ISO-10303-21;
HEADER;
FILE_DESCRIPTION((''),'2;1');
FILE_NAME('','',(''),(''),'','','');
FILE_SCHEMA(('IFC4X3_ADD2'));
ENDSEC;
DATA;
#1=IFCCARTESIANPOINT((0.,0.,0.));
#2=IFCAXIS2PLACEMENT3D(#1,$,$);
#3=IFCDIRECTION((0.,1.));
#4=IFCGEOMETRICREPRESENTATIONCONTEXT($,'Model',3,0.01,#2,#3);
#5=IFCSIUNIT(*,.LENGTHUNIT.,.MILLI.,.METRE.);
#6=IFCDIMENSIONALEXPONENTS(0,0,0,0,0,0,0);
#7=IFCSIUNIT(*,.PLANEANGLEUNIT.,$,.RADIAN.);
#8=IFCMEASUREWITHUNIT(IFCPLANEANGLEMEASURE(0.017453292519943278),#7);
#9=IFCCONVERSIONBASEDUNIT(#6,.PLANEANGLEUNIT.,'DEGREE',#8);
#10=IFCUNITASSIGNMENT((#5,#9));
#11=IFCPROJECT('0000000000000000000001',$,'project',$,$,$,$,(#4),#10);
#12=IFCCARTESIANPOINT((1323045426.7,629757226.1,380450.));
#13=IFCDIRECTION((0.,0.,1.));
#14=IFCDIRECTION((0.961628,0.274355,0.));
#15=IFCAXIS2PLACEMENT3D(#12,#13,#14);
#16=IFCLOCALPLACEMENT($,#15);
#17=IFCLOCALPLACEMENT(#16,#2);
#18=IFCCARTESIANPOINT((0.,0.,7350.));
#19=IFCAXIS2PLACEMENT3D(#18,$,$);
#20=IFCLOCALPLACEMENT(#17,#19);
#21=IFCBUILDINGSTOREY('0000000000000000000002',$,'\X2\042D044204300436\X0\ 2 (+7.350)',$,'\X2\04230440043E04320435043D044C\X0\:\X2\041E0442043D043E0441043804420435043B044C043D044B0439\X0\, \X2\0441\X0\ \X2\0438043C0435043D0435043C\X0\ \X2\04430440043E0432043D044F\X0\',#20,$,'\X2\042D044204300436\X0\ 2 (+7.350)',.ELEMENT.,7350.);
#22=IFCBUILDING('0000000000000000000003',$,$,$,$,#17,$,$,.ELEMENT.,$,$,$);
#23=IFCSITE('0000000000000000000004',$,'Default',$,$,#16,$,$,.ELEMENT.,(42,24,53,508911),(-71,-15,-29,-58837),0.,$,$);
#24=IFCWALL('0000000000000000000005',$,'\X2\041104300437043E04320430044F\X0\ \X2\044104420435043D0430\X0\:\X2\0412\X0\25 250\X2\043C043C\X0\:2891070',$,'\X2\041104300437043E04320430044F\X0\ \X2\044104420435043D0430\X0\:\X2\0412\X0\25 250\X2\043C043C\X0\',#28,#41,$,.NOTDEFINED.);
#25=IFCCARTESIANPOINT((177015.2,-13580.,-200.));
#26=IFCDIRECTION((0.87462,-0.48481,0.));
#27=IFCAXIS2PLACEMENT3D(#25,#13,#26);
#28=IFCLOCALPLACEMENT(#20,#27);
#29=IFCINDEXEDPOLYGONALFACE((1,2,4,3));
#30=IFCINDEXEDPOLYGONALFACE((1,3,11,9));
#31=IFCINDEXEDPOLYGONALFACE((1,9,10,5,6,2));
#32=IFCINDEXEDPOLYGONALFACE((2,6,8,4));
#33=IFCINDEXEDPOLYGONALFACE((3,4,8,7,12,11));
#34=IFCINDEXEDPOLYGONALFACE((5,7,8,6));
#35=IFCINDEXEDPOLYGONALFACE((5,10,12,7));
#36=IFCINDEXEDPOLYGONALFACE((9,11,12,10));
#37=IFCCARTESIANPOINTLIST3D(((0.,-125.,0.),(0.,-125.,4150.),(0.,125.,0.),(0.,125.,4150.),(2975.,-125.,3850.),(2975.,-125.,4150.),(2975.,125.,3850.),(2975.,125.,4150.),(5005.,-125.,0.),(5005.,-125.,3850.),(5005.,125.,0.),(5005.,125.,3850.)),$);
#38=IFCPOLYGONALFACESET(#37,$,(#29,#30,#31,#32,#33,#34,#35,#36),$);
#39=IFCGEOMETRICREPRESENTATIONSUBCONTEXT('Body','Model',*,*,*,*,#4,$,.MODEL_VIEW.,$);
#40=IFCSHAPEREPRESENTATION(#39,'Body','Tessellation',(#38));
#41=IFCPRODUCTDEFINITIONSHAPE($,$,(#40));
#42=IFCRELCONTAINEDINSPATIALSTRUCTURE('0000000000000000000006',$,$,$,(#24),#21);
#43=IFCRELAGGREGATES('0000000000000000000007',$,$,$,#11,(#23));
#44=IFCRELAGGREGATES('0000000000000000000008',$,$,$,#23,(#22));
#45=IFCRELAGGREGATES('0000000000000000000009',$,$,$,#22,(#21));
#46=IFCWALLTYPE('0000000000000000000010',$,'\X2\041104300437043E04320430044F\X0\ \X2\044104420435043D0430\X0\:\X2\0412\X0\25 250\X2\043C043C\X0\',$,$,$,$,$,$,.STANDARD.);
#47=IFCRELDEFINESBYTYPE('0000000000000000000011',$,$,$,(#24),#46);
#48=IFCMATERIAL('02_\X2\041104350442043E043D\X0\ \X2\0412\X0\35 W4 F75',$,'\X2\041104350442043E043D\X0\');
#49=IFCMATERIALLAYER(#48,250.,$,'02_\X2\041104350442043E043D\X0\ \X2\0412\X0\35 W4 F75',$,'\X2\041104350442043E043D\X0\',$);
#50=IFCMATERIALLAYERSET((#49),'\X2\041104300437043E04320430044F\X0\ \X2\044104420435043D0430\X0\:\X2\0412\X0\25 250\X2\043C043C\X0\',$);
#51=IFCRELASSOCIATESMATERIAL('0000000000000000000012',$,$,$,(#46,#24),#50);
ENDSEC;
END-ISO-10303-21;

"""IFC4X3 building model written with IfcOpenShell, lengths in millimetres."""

from ifc_helpers import new_model, entity, si_unit, converted_unit, direction, frame, frame_2d, origin, place, context, subcontext, project, spatial, polyline, rectangle, extrude, clip, bounded_halfspace, material, layer, layer_set, type_object, element, save


model = new_model("IFC4X3")

# Units and contexts
model_context = context("Model", 3, precision=0.01, world=origin(), true_north=direction((0.0, 1.0)))
body_context = subcontext(model_context, "Body", "Model", "MODEL_VIEW")
ifc_project = project(units=[si_unit("LENGTHUNIT", "METRE", prefix="MILLI"), converted_unit("PLANEANGLEUNIT", "DEGREE", entity("IfcPlaneAngleMeasure", 0.017453292519943278), si_unit("PLANEANGLEUNIT", "RADIAN"), dimensions=[0, 0, 0, 0, 0, 0, 0])], contexts=[model_context])

# Site, building, storey
site_placement = place(None, frame((1323045426.7, 629757226.1, 380450.0), z_axis=(0.0, 0.0, 1.0), x_axis=(0.961628, 0.274355, 0.0)))
site = spatial("IfcSite", under=ifc_project, at=site_placement, Name="Default", CompositionType="ELEMENT", RefLatitude=(42, 24, 53, 508911), RefLongitude=(-71, -15, -29, -58837), RefElevation=0.0)
building_placement = place(site_placement, origin())
building = spatial("IfcBuilding", under=site, at=building_placement, CompositionType="ELEMENT")
storey_placement = place(building_placement, frame((0.0, 0.0, 7350.0)))
storey = spatial("IfcBuildingStorey", under=building, at=storey_placement, Name="Этаж 2 (+7.350)", ObjectType="Уровень:Относительный, с именем уровня", LongName="Этаж 2 (+7.350)", CompositionType="ELEMENT", Elevation=7350.0)

# Shared definitions
ifc_material = material(Name="02_Бетон В35 W4 F75", Category="Бетон")
ifc_layer_1 = layer(ifc_material, 250.0, Name="02_Бетон В35 W4 F75", Category="Бетон")
ifc_layer_set_1 = layer_set([ifc_layer_1], Name="Базовая стена:В25 250мм")
wall_type_1 = type_object("IfcWallType", Name="Базовая стена:В25 250мм", PredefinedType="STANDARD", material=ifc_layer_set_1)

# Wall, openings
wall_1_placement = place(storey_placement, frame((177015.2, -13580.0, -200.0), z_axis=(0.0, 0.0, 1.0), x_axis=(0.87462, -0.48481, 0.0)))
wall_1 = element("IfcWall", 1, at=wall_1_placement, inside=storey, type_object=wall_type_1, material=ifc_layer_set_1, Name="Базовая стена:В25 250мм:2891070", ObjectType="Базовая стена:В25 250мм", PredefinedType="NOTDEFINED", context=body_context, shape_type="Clipping", body=[
    clip(extrude(rectangle(XDim=5005.0, YDim=250.0, at=frame_2d((2502.5, 0.0), x_axis=(-1.0, 0.0))), origin(), (0.0, 0.0, 1.0), 4150.0), bounded_halfspace(frame((0.0, -125.0, 4150.0), z_axis=(0.0, 0.0, -1.0), x_axis=(0.0, -1.0, 0.0)), True, frame((0.0, -125.0, 4150.0)), polyline([(0.0, 0.0), (2975.0, 0.0), (2975.0, 250.0), (250.0, 250.0), (0.0, 250.0), (0.0, 0.0)]))),
])
opening_1_placement = place(wall_1_placement, frame((-161404.7, -73941.3, 0.0)))
element("IfcOpeningElement", 2, at=opening_1_placement, cuts=wall_1, PredefinedType="OPENING", context=body_context, shape_type="SweptSolid", body=[
    extrude(rectangle(XDim=2300.0, YDim=250.0, at=frame_2d((0.0, 0.0), x_axis=(0.0, 1.0))), frame((164879.7, 74066.3, 1150.0), z_axis=(0.0, 1.0, 0.0), x_axis=(1.0, 0.0, 0.0)), (0.0, 0.0, 1.0), 1700.0),
])
opening_2_placement = place(wall_1_placement, origin())
element("IfcOpeningElement", 3, at=opening_2_placement, cuts=wall_1, PredefinedType="OPENING", context=body_context, shape_type="SweptSolid", body=[
    extrude(rectangle(XDim=300.0, YDim=2030.0, at=frame_2d((0.0, 0.0), x_axis=(1.0, 0.0))), frame((3990.0, 125.0, 4000.0), z_axis=(0.0, -1.0, 0.0), x_axis=(0.0, 0.0, 1.0)), (0.0, 0.0, 1.0), 250.0),
])

save(model, "model.ifc")
